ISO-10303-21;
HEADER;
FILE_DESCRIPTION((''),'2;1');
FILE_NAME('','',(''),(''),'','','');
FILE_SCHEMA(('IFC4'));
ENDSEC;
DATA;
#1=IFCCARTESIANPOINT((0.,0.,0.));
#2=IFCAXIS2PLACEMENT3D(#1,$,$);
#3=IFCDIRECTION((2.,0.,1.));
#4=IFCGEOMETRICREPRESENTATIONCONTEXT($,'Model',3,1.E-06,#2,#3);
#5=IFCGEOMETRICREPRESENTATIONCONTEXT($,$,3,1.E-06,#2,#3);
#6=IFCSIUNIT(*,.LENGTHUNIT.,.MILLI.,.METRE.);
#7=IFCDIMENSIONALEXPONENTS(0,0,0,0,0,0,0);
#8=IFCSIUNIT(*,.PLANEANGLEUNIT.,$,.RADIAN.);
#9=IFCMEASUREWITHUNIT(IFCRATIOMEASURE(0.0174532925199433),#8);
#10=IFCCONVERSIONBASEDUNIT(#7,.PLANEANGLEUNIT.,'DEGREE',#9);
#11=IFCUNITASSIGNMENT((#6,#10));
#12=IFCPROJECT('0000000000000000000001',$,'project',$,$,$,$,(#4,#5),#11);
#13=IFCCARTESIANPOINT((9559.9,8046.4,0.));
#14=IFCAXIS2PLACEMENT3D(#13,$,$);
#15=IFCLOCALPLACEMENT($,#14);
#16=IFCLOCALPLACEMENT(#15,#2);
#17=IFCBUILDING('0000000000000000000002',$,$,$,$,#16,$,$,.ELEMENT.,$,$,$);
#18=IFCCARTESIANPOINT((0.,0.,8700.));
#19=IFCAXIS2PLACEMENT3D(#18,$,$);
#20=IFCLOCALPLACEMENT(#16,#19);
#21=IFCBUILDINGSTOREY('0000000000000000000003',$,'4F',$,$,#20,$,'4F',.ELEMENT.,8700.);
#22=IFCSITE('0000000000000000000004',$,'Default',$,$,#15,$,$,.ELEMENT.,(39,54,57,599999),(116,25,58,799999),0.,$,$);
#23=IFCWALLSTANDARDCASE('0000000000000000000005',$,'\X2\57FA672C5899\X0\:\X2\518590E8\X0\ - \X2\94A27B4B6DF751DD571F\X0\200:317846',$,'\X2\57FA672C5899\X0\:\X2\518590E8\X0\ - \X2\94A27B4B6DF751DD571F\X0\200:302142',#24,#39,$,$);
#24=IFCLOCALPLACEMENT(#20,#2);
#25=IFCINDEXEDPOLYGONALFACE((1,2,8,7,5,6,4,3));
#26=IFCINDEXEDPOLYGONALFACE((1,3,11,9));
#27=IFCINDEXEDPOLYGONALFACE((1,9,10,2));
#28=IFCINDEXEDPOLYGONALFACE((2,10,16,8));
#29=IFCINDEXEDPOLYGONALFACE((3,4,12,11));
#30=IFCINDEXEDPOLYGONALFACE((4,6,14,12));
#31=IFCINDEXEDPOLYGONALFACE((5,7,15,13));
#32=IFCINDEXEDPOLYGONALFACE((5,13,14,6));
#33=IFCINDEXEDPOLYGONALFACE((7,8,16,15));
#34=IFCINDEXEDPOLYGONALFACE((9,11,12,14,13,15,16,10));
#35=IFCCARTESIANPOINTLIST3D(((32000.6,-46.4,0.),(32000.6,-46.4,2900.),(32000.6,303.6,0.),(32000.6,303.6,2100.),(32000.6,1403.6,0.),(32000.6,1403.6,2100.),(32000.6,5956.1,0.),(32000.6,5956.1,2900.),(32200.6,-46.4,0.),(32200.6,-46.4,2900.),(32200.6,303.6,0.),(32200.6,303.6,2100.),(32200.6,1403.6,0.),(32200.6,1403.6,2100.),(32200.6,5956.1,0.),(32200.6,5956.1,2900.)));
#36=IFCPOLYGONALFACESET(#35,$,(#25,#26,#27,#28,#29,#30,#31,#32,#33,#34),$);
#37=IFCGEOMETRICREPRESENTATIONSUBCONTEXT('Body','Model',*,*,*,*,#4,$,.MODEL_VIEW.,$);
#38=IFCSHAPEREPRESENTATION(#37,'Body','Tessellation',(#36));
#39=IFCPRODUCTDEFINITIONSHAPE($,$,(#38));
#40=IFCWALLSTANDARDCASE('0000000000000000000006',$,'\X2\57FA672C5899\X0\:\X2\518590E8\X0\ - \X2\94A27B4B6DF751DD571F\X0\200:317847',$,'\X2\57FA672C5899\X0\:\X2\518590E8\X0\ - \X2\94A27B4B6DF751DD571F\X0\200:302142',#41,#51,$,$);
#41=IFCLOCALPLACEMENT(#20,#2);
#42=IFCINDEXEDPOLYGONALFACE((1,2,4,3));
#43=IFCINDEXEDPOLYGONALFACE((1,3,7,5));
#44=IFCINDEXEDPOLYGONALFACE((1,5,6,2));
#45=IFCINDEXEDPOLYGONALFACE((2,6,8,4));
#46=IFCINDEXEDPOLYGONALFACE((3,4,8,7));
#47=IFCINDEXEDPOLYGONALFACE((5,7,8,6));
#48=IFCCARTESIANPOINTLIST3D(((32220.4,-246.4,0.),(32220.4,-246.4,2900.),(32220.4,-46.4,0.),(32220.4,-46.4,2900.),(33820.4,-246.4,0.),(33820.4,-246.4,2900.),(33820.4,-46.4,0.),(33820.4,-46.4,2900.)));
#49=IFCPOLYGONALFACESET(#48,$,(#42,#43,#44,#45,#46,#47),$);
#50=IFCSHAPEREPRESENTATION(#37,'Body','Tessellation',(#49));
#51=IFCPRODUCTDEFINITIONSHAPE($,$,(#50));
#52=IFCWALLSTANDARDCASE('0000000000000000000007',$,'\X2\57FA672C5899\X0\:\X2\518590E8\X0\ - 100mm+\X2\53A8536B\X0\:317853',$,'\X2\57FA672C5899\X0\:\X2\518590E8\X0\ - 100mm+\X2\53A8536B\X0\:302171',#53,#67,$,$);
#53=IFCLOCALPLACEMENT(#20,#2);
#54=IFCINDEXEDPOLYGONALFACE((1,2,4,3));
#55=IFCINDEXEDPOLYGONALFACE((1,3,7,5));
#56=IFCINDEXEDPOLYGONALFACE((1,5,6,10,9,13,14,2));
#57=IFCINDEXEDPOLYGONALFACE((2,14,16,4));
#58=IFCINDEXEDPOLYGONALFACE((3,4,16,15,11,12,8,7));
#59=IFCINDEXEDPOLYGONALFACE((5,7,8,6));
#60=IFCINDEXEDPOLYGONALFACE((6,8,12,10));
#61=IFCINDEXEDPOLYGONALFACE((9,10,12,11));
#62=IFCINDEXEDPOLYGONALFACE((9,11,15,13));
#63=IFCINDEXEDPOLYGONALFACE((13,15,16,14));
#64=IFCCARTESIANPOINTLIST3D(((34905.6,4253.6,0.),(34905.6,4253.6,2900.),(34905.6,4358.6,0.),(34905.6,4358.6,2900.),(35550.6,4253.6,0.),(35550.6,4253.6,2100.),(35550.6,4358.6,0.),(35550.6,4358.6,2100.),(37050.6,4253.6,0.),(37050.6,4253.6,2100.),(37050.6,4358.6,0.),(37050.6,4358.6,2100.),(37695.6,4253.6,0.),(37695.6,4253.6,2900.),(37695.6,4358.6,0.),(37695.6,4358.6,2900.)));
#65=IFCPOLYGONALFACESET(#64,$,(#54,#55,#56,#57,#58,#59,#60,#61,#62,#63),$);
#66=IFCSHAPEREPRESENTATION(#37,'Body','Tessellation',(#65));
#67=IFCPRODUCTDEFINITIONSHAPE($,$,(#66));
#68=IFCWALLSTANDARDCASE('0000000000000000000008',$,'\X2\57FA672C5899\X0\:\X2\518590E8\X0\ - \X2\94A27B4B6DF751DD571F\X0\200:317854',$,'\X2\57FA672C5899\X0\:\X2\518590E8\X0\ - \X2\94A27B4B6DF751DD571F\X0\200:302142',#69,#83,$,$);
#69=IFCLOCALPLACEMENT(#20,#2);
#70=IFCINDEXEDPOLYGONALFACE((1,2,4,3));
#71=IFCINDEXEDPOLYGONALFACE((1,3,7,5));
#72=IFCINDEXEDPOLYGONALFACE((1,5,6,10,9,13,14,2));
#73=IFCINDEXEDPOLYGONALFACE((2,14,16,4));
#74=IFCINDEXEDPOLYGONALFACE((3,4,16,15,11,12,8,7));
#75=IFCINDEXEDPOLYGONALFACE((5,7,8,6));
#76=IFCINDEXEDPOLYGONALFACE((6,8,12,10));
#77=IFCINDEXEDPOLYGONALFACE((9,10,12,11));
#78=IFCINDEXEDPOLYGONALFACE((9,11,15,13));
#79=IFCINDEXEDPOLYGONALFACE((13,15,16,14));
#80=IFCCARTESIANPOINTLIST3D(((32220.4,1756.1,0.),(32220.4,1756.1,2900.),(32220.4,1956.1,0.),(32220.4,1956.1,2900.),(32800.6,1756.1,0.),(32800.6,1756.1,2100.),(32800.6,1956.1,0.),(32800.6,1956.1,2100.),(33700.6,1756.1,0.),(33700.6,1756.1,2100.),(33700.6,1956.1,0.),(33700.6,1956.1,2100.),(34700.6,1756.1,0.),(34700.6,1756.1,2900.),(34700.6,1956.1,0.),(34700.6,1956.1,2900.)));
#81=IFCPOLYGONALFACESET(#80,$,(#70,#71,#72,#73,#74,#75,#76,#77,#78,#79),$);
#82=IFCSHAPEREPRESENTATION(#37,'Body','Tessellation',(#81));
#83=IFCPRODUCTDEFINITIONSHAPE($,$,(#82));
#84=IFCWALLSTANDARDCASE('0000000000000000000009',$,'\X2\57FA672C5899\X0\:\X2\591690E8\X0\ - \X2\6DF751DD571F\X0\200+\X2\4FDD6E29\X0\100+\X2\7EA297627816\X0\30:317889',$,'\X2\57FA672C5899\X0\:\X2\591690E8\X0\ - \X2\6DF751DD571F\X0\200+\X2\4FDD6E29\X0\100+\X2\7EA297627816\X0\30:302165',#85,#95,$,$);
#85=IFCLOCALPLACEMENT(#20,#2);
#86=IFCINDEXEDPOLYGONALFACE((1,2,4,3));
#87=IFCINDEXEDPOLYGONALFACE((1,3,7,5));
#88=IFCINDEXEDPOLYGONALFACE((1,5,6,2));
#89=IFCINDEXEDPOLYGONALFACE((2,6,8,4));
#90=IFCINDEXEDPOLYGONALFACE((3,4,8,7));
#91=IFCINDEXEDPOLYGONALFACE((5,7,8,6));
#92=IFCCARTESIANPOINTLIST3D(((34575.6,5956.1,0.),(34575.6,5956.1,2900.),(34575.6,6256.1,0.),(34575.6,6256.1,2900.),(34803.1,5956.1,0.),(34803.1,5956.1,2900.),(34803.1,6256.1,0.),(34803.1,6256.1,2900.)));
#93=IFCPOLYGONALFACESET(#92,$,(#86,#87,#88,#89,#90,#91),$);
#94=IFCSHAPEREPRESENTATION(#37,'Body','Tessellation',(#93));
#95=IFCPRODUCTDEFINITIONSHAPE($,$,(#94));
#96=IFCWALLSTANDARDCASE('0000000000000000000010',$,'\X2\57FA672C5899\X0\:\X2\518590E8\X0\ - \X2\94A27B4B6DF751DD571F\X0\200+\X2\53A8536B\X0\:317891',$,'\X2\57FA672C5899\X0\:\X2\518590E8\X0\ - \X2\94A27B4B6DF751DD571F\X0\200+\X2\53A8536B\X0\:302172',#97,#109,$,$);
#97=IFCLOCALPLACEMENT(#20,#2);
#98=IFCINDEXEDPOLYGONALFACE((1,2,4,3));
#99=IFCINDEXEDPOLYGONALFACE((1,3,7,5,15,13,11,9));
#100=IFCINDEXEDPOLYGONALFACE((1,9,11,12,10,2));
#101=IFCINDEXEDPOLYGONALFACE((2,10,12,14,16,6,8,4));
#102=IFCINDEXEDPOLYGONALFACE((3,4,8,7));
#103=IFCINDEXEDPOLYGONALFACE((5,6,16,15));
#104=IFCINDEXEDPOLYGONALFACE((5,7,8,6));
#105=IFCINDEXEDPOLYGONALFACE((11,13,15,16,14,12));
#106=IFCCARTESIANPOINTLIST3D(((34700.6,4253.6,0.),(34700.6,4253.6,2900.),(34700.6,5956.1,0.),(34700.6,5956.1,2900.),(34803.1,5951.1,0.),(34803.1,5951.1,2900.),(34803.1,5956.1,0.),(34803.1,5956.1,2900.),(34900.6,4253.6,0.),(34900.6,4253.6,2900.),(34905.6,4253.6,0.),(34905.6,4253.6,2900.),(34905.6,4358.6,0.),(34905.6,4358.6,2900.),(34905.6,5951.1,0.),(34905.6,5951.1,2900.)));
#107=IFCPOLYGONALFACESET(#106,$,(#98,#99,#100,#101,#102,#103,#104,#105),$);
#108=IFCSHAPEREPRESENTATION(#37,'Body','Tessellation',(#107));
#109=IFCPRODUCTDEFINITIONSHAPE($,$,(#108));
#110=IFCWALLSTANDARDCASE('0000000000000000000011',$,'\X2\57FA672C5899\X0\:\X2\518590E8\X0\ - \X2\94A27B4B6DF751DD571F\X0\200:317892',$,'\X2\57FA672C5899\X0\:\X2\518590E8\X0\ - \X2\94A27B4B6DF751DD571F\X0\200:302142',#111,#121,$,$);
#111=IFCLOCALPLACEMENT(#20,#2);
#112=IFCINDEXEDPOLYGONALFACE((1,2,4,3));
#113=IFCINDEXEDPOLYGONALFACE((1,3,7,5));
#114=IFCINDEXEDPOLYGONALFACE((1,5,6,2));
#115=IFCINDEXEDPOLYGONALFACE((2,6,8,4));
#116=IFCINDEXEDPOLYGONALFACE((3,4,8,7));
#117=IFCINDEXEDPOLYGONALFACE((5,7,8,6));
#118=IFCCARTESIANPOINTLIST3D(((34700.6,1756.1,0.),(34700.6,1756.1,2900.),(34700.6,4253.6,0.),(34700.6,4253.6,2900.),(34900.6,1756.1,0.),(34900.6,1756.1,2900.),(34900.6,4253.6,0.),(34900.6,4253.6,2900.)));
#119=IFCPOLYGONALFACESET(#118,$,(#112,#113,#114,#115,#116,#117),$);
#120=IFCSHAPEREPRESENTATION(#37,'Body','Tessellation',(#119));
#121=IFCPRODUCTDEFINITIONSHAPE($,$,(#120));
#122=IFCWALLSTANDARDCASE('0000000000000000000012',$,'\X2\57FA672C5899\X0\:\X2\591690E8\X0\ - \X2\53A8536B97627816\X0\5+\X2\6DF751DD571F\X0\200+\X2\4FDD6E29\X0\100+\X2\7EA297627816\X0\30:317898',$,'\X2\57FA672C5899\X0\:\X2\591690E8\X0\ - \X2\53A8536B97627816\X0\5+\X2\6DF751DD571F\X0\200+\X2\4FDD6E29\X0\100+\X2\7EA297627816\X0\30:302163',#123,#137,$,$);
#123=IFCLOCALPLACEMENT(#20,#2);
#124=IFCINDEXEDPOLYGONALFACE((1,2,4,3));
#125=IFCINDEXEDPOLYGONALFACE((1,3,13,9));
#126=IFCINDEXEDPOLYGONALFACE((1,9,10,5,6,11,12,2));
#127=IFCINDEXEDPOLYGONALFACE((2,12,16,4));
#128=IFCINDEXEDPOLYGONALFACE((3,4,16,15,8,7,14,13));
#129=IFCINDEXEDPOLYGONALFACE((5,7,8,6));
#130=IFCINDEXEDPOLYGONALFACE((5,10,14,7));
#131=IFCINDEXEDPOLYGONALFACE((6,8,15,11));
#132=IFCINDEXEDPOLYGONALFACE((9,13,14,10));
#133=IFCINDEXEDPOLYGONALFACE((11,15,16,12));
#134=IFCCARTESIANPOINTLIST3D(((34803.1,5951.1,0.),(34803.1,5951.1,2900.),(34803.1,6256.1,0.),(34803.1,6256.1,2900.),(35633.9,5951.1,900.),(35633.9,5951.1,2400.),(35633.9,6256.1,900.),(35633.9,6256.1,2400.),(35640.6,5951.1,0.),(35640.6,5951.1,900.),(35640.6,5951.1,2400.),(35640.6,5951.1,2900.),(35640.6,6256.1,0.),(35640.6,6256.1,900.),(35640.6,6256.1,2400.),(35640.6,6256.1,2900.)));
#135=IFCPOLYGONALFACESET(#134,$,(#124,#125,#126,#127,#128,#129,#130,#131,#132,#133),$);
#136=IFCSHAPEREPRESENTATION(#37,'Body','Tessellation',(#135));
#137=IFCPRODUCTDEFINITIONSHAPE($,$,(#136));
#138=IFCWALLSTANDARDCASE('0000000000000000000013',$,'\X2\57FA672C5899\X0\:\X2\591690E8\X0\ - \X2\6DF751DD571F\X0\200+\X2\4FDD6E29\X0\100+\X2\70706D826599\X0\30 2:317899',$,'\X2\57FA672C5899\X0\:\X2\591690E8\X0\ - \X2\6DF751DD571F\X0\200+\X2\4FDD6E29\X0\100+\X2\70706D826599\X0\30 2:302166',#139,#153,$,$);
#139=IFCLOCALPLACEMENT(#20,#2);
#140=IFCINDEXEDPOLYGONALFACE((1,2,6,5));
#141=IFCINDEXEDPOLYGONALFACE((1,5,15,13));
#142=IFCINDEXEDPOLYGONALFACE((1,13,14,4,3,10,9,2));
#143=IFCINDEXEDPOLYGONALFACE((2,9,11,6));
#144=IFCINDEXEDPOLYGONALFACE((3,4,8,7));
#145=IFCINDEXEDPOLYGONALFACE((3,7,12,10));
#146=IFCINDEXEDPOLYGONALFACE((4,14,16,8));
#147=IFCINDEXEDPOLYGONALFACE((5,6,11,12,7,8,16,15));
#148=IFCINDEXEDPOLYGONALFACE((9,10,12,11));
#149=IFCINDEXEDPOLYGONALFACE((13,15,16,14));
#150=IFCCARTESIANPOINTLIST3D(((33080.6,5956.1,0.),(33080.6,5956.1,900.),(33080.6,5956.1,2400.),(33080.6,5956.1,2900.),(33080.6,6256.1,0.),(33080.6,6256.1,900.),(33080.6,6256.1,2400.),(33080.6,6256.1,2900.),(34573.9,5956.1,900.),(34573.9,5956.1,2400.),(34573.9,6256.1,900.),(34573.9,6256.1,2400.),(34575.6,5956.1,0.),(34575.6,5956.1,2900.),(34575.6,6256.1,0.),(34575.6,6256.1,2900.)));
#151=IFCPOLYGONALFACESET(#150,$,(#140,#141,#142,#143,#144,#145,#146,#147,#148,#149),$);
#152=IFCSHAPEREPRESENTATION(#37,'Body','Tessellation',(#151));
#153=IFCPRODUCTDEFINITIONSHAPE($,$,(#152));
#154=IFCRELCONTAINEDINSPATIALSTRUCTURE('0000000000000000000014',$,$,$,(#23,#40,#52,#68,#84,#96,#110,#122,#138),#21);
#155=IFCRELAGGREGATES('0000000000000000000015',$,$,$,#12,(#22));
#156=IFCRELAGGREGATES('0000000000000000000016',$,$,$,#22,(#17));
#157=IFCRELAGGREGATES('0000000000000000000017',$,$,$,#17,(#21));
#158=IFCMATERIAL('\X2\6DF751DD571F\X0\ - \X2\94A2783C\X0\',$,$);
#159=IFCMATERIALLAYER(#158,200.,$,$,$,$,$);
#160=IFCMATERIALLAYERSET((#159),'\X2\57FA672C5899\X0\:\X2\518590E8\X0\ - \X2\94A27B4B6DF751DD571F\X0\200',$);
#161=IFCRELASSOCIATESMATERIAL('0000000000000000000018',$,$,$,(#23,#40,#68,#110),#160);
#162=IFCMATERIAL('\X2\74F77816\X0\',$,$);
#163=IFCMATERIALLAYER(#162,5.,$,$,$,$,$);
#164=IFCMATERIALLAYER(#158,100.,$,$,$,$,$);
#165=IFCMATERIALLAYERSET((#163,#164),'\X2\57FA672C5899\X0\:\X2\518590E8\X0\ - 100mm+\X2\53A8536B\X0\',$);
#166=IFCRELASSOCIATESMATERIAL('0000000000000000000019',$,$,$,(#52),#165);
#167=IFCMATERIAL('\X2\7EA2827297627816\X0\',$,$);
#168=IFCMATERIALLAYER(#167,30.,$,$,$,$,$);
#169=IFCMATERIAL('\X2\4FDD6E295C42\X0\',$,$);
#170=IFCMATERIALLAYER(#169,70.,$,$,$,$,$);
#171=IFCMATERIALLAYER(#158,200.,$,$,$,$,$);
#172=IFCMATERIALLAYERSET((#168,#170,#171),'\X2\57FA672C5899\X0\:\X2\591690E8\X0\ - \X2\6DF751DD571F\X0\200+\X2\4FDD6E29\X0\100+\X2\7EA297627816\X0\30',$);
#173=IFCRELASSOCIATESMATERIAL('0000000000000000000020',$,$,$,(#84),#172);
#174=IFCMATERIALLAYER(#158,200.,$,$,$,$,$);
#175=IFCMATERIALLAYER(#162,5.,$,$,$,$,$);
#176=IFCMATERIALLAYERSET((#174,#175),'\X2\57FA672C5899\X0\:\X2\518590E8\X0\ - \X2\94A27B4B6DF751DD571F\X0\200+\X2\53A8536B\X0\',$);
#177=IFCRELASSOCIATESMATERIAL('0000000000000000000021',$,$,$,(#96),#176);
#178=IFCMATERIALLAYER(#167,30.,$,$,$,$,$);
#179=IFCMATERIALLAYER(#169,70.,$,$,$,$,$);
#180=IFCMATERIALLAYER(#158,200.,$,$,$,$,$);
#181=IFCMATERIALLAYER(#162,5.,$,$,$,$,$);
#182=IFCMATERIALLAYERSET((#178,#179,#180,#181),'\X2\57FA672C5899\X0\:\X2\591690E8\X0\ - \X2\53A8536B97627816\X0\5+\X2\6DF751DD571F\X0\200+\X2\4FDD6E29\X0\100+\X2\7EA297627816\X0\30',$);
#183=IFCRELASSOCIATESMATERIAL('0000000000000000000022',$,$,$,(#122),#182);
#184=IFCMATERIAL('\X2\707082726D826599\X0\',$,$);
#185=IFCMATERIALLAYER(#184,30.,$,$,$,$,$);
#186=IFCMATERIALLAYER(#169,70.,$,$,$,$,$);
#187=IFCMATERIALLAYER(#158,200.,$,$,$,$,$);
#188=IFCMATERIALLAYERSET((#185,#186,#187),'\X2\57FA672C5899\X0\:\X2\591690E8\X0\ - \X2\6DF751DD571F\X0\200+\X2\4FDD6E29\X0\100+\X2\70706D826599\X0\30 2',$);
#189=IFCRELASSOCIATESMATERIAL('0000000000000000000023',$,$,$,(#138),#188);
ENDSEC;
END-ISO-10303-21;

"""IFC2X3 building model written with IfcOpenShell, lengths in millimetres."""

from ifc_helpers import new_model, entity, si_unit, converted_unit, direction, frame, frame_2d, origin, place, context, subcontext, project, spatial, polyline, rectangle, outline, extrude, material, layer, layer_set, layer_usage, element, save


model = new_model("IFC2X3")

# Units and contexts
model_context = context("Model", 3, precision=1e-06, world=origin(), true_north=direction((2.0, 0.0, 1.0)))
context_of_model = context(None, 3, precision=1e-06, world=origin(), true_north=direction((2.0, 0.0, 1.0)))
body_context = subcontext(model_context, "Body", "Model", "MODEL_VIEW")
ifc_project = project(units=[si_unit("LENGTHUNIT", "METRE", prefix="MILLI"), converted_unit("PLANEANGLEUNIT", "DEGREE", entity("IfcRatioMeasure", 0.0174532925199433), si_unit("PLANEANGLEUNIT", "RADIAN"), dimensions=[0, 0, 0, 0, 0, 0, 0])], contexts=[model_context, context_of_model])

# Site, building, storey
site_placement = place(None, frame((9559.9, 8046.4, 0.0)))
site = spatial("IfcSite", under=ifc_project, at=site_placement, Name="Default", CompositionType="ELEMENT", RefLatitude=(39, 54, 57, 599999), RefLongitude=(116, 25, 58, 799999), RefElevation=0.0)
building_placement = place(site_placement, origin())
building = spatial("IfcBuilding", under=site, at=building_placement, CompositionType="ELEMENT")
storey_placement = place(building_placement, frame((0.0, 0.0, 8700.0)))
storey = spatial("IfcBuildingStorey", under=building, at=storey_placement, Name="4F", LongName="4F", CompositionType="ELEMENT", Elevation=8700.0)

# Shared definitions
ifc_material_1 = material(Name="混凝土 - 钢砼")
ifc_layer_1 = layer(ifc_material_1, 200.0)
ifc_material_2 = material(Name="瓷砖")
ifc_layer_2 = layer(ifc_material_2, 5.0)
ifc_layer_set_1 = layer_set([ifc_layer_1, ifc_layer_2], Name="基本墙:内部 - 钢筋混凝土200+厨卫")

# Wall, opening
ifc_layer_3 = layer(ifc_material_1, 200.0)
ifc_layer_set_2 = layer_set([ifc_layer_3], Name="基本墙:内部 - 钢筋混凝土200")
ifc_layer_usage_1 = layer_usage(ifc_layer_set_2, "AXIS2", "POSITIVE", -100.0)
wall_1_placement = place(storey_placement, frame((32100.6, 5956.1, 0.0), z_axis=(0.0, 0.0, 1.0), x_axis=(0.0, -1.0, 0.0)))
wall_1 = element("IfcWallStandardCase", 1, at=wall_1_placement, inside=storey, material=ifc_layer_usage_1, Name="基本墙:内部 - 钢筋混凝土200:317846", ObjectType="基本墙:内部 - 钢筋混凝土200:302142", context=body_context, shape_type="SweptSolid", body=[
    extrude(rectangle(XDim=6002.5, YDim=200.0, at=frame_2d((3001.2, 0.0), x_axis=(-1.0, 0.0))), origin(), (0.0, 0.0, 1.0), 2900.0),
])
opening_1_placement = place(wall_1_placement, frame((5652.5, 100.0, 0.0)))
element("IfcOpeningElement", 2, at=opening_1_placement, cuts=wall_1, ObjectType="Opening", context=body_context, shape_type="SweptSolid", body=[
    extrude(rectangle(XDim=2100.0, YDim=1100.0, at=frame_2d((1050.0, 550.0), x_axis=(1.0, 0.0))), frame((0.0, 0.0, 0.0), z_axis=(0.0, -1.0, 0.0), x_axis=(0.0, 0.0, 1.0)), (0.0, 0.0, 1.0), 200.0),
])

# Wall
ifc_layer_usage_2 = layer_usage(ifc_layer_set_2, "AXIS2", "POSITIVE", -100.0)
wall_2_placement = place(storey_placement, frame((32220.4, -146.4, 0.0)))
element("IfcWallStandardCase", 3, at=wall_2_placement, inside=storey, material=ifc_layer_usage_2, Name="基本墙:内部 - 钢筋混凝土200:317847", ObjectType="基本墙:内部 - 钢筋混凝土200:302142", context=body_context, shape_type="SweptSolid", body=[
    extrude(rectangle(XDim=1600.0, YDim=200.0, at=frame_2d((800.0, 0.0), x_axis=(-1.0, 0.0))), origin(), (0.0, 0.0, 1.0), 2900.0),
])

# Walls, openings
ifc_layer_4 = layer(ifc_material_2, 5.0)
ifc_layer_5 = layer(ifc_material_1, 100.0)
ifc_layer_set_3 = layer_set([ifc_layer_4, ifc_layer_5], Name="基本墙:内部 - 100mm+厨卫")
ifc_layer_usage_3 = layer_usage(ifc_layer_set_3, "AXIS2", "POSITIVE", -52.5)
wall_3_placement = place(storey_placement, frame((37695.6, 4306.1, 0.0), z_axis=(0.0, 0.0, 1.0), x_axis=(-1.0, 0.0, 0.0)))
wall_3 = element("IfcWallStandardCase", 4, at=wall_3_placement, inside=storey, material=ifc_layer_usage_3, Name="基本墙:内部 - 100mm+厨卫:317853", ObjectType="基本墙:内部 - 100mm+厨卫:302171", context=body_context, shape_type="SweptSolid", body=[
    extrude(rectangle(XDim=2790.0, YDim=105.0, at=frame_2d((1395.0, 0.0), x_axis=(-1.0, 0.0))), origin(), (0.0, 0.0, 1.0), 2900.0),
])
opening_2_placement = place(wall_3_placement, frame((645.0, -52.5, 0.0)))
element("IfcOpeningElement", 5, at=opening_2_placement, cuts=wall_3, ObjectType="Opening", context=body_context, shape_type="SweptSolid", body=[
    extrude(rectangle(XDim=2100.0, YDim=1500.0, at=frame_2d((1050.0, 750.0), x_axis=(1.0, 0.0))), frame((0.0, 0.0, 0.0), z_axis=(0.0, 1.0, 0.0), x_axis=(0.0, 0.0, 1.0)), (0.0, 0.0, 1.0), 105.0),
])
ifc_layer_usage_4 = layer_usage(ifc_layer_set_2, "AXIS2", "POSITIVE", -100.0)
wall_4_placement = place(storey_placement, frame((34700.6, 1856.1, 0.0), z_axis=(0.0, 0.0, 1.0), x_axis=(-1.0, 0.0, 0.0)))
wall_4 = element("IfcWallStandardCase", 6, at=wall_4_placement, inside=storey, material=ifc_layer_usage_4, Name="基本墙:内部 - 钢筋混凝土200:317854", ObjectType="基本墙:内部 - 钢筋混凝土200:302142", context=body_context, shape_type="SweptSolid", body=[
    extrude(rectangle(XDim=2480.2, YDim=200.0, at=frame_2d((1240.1, 0.0), x_axis=(-1.0, 0.0))), origin(), (0.0, 0.0, 1.0), 2900.0),
])
opening_3_placement = place(wall_4_placement, frame((1900.0, 100.0, 0.0)))
element("IfcOpeningElement", 7, at=opening_3_placement, cuts=wall_4, ObjectType="Opening", context=body_context, shape_type="SweptSolid", body=[
    extrude(rectangle(XDim=2100.0, YDim=900.0, at=frame_2d((1050.0, 450.0), x_axis=(1.0, 0.0))), frame((0.0, 0.0, 0.0), z_axis=(0.0, -1.0, 0.0), x_axis=(0.0, 0.0, 1.0)), (0.0, 0.0, 1.0), 200.0),
])

# Walls
ifc_material_3 = material(Name="红色面砖")
ifc_layer_6 = layer(ifc_material_3, 30.0)
ifc_material_4 = material(Name="保温层")
ifc_layer_7 = layer(ifc_material_4, 70.0)
ifc_layer_8 = layer(ifc_material_1, 200.0)
ifc_layer_set_4 = layer_set([ifc_layer_6, ifc_layer_7, ifc_layer_8], Name="基本墙:外部 - 混凝土200+保温100+红面砖30")
ifc_layer_usage_5 = layer_usage(ifc_layer_set_4, "AXIS2", "POSITIVE", -150.0)
wall_5_placement = place(storey_placement, frame((34803.1, 6106.1, 0.0), z_axis=(0.0, 0.0, 1.0), x_axis=(-1.0, 0.0, 0.0)))
element("IfcWallStandardCase", 8, at=wall_5_placement, inside=storey, material=ifc_layer_usage_5, Name="基本墙:外部 - 混凝土200+保温100+红面砖30:317889", ObjectType="基本墙:外部 - 混凝土200+保温100+红面砖30:302165", context=body_context, shape_type="SweptSolid", body=[
    extrude(rectangle(XDim=227.5, YDim=300.0, at=frame_2d((113.8, 0.0), x_axis=(-1.0, 0.0))), origin(), (0.0, 0.0, 1.0), 2900.0),
])
ifc_layer_usage_6 = layer_usage(ifc_layer_set_1, "AXIS2", "POSITIVE", -102.5)
wall_6_placement = place(storey_placement, frame((34803.1, 5956.1, 0.0), z_axis=(0.0, 0.0, 1.0), x_axis=(0.0, -1.0, 0.0)))
element("IfcWallStandardCase", 9, at=wall_6_placement, inside=storey, material=ifc_layer_usage_6, Name="基本墙:内部 - 钢筋混凝土200+厨卫:317891", ObjectType="基本墙:内部 - 钢筋混凝土200+厨卫:302172", context=body_context, shape_type="SweptSolid", body=[
    extrude(outline(polyline([(1702.5, -102.5), (1702.5, 97.5), (1702.5, 102.5), (1597.5, 102.5), (5.0, 102.5), (5.0, 0.0), (0.0, 0.0), (0.0, -102.5), (1702.5, -102.5)])), origin(), (0.0, 0.0, 1.0), 2900.0),
])
ifc_layer_usage_7 = layer_usage(ifc_layer_set_2, "AXIS2", "POSITIVE", -100.0)
wall_7_placement = place(storey_placement, frame((34800.6, 4253.6, 0.0), z_axis=(0.0, 0.0, 1.0), x_axis=(0.0, -1.0, 0.0)))
element("IfcWallStandardCase", 10, at=wall_7_placement, inside=storey, material=ifc_layer_usage_7, Name="基本墙:内部 - 钢筋混凝土200:317892", ObjectType="基本墙:内部 - 钢筋混凝土200:302142", context=body_context, shape_type="SweptSolid", body=[
    extrude(rectangle(XDim=2497.5, YDim=200.0, at=frame_2d((1248.8, 0.0), x_axis=(-1.0, 0.0))), origin(), (0.0, 0.0, 1.0), 2900.0),
])

# Walls, openings
ifc_layer_9 = layer(ifc_material_3, 30.0)
ifc_layer_10 = layer(ifc_material_4, 70.0)
ifc_layer_11 = layer(ifc_material_1, 200.0)
ifc_layer_12 = layer(ifc_material_2, 5.0)
ifc_layer_set_5 = layer_set([ifc_layer_9, ifc_layer_10, ifc_layer_11, ifc_layer_12], Name="基本墙:外部 - 厨卫面砖5+混凝土200+保温100+红面砖30")
ifc_layer_usage_8 = layer_usage(ifc_layer_set_5, "AXIS2", "POSITIVE", -152.5)
wall_8_placement = place(storey_placement, frame((35640.6, 6103.6, 0.0), z_axis=(0.0, 0.0, 1.0), x_axis=(-1.0, 0.0, 0.0)))
wall_8 = element("IfcWallStandardCase", 11, at=wall_8_placement, inside=storey, material=ifc_layer_usage_8, Name="基本墙:外部 - 厨卫面砖5+混凝土200+保温100+红面砖30:317898", ObjectType="基本墙:外部 - 厨卫面砖5+混凝土200+保温100+红面砖30:302163", context=body_context, shape_type="SweptSolid", body=[
    extrude(rectangle(XDim=837.5, YDim=305.0, at=frame_2d((418.8, 0.0), x_axis=(-1.0, 0.0))), origin(), (0.0, 0.0, 1.0), 2900.0),
])
opening_4_placement = place(wall_8_placement, frame((6.7, 152.5, 900.0)))
element("IfcOpeningElement", 12, at=opening_4_placement, cuts=wall_8, ObjectType="Opening", context=body_context, shape_type="SweptSolid", body=[
    extrude(rectangle(XDim=1500.0, YDim=1800.0, at=frame_2d((750.0, 900.0), x_axis=(1.0, 0.0))), frame((0.0, 0.0, 0.0), z_axis=(0.0, -1.0, 0.0), x_axis=(0.0, 0.0, 1.0)), (0.0, 0.0, 1.0), 305.0),
])
ifc_material_5 = material(Name="灰色涂料")
ifc_layer_13 = layer(ifc_material_5, 30.0)
ifc_layer_14 = layer(ifc_material_4, 70.0)
ifc_layer_15 = layer(ifc_material_1, 200.0)
ifc_layer_set_6 = layer_set([ifc_layer_13, ifc_layer_14, ifc_layer_15], Name="基本墙:外部 - 混凝土200+保温100+灰涂料30 2")
ifc_layer_usage_9 = layer_usage(ifc_layer_set_6, "AXIS2", "POSITIVE", -150.0)
wall_9_placement = place(storey_placement, frame((34575.6, 6106.1, 0.0), z_axis=(0.0, 0.0, 1.0), x_axis=(-1.0, 0.0, 0.0)))
wall_9 = element("IfcWallStandardCase", 13, at=wall_9_placement, inside=storey, material=ifc_layer_usage_9, Name="基本墙:外部 - 混凝土200+保温100+灰涂料30 2:317899", ObjectType="基本墙:外部 - 混凝土200+保温100+灰涂料30 2:302166", context=body_context, shape_type="SweptSolid", body=[
    extrude(rectangle(XDim=1495.0, YDim=300.0, at=frame_2d((747.5, 0.0), x_axis=(-1.0, 0.0))), origin(), (0.0, 0.0, 1.0), 2900.0),
])
opening_5_placement = place(wall_9_placement, frame((1501.7, 150.0, 900.0)))
element("IfcOpeningElement", 14, at=opening_5_placement, cuts=wall_9, ObjectType="Opening", context=body_context, shape_type="SweptSolid", body=[
    extrude(rectangle(XDim=1500.0, YDim=1500.0, at=frame_2d((750.0, 750.0), x_axis=(1.0, 0.0))), frame((0.0, 0.0, 0.0), z_axis=(0.0, -1.0, 0.0), x_axis=(0.0, 0.0, 1.0)), (0.0, 0.0, 1.0), 300.0),
])

save(model, "model.ifc")
